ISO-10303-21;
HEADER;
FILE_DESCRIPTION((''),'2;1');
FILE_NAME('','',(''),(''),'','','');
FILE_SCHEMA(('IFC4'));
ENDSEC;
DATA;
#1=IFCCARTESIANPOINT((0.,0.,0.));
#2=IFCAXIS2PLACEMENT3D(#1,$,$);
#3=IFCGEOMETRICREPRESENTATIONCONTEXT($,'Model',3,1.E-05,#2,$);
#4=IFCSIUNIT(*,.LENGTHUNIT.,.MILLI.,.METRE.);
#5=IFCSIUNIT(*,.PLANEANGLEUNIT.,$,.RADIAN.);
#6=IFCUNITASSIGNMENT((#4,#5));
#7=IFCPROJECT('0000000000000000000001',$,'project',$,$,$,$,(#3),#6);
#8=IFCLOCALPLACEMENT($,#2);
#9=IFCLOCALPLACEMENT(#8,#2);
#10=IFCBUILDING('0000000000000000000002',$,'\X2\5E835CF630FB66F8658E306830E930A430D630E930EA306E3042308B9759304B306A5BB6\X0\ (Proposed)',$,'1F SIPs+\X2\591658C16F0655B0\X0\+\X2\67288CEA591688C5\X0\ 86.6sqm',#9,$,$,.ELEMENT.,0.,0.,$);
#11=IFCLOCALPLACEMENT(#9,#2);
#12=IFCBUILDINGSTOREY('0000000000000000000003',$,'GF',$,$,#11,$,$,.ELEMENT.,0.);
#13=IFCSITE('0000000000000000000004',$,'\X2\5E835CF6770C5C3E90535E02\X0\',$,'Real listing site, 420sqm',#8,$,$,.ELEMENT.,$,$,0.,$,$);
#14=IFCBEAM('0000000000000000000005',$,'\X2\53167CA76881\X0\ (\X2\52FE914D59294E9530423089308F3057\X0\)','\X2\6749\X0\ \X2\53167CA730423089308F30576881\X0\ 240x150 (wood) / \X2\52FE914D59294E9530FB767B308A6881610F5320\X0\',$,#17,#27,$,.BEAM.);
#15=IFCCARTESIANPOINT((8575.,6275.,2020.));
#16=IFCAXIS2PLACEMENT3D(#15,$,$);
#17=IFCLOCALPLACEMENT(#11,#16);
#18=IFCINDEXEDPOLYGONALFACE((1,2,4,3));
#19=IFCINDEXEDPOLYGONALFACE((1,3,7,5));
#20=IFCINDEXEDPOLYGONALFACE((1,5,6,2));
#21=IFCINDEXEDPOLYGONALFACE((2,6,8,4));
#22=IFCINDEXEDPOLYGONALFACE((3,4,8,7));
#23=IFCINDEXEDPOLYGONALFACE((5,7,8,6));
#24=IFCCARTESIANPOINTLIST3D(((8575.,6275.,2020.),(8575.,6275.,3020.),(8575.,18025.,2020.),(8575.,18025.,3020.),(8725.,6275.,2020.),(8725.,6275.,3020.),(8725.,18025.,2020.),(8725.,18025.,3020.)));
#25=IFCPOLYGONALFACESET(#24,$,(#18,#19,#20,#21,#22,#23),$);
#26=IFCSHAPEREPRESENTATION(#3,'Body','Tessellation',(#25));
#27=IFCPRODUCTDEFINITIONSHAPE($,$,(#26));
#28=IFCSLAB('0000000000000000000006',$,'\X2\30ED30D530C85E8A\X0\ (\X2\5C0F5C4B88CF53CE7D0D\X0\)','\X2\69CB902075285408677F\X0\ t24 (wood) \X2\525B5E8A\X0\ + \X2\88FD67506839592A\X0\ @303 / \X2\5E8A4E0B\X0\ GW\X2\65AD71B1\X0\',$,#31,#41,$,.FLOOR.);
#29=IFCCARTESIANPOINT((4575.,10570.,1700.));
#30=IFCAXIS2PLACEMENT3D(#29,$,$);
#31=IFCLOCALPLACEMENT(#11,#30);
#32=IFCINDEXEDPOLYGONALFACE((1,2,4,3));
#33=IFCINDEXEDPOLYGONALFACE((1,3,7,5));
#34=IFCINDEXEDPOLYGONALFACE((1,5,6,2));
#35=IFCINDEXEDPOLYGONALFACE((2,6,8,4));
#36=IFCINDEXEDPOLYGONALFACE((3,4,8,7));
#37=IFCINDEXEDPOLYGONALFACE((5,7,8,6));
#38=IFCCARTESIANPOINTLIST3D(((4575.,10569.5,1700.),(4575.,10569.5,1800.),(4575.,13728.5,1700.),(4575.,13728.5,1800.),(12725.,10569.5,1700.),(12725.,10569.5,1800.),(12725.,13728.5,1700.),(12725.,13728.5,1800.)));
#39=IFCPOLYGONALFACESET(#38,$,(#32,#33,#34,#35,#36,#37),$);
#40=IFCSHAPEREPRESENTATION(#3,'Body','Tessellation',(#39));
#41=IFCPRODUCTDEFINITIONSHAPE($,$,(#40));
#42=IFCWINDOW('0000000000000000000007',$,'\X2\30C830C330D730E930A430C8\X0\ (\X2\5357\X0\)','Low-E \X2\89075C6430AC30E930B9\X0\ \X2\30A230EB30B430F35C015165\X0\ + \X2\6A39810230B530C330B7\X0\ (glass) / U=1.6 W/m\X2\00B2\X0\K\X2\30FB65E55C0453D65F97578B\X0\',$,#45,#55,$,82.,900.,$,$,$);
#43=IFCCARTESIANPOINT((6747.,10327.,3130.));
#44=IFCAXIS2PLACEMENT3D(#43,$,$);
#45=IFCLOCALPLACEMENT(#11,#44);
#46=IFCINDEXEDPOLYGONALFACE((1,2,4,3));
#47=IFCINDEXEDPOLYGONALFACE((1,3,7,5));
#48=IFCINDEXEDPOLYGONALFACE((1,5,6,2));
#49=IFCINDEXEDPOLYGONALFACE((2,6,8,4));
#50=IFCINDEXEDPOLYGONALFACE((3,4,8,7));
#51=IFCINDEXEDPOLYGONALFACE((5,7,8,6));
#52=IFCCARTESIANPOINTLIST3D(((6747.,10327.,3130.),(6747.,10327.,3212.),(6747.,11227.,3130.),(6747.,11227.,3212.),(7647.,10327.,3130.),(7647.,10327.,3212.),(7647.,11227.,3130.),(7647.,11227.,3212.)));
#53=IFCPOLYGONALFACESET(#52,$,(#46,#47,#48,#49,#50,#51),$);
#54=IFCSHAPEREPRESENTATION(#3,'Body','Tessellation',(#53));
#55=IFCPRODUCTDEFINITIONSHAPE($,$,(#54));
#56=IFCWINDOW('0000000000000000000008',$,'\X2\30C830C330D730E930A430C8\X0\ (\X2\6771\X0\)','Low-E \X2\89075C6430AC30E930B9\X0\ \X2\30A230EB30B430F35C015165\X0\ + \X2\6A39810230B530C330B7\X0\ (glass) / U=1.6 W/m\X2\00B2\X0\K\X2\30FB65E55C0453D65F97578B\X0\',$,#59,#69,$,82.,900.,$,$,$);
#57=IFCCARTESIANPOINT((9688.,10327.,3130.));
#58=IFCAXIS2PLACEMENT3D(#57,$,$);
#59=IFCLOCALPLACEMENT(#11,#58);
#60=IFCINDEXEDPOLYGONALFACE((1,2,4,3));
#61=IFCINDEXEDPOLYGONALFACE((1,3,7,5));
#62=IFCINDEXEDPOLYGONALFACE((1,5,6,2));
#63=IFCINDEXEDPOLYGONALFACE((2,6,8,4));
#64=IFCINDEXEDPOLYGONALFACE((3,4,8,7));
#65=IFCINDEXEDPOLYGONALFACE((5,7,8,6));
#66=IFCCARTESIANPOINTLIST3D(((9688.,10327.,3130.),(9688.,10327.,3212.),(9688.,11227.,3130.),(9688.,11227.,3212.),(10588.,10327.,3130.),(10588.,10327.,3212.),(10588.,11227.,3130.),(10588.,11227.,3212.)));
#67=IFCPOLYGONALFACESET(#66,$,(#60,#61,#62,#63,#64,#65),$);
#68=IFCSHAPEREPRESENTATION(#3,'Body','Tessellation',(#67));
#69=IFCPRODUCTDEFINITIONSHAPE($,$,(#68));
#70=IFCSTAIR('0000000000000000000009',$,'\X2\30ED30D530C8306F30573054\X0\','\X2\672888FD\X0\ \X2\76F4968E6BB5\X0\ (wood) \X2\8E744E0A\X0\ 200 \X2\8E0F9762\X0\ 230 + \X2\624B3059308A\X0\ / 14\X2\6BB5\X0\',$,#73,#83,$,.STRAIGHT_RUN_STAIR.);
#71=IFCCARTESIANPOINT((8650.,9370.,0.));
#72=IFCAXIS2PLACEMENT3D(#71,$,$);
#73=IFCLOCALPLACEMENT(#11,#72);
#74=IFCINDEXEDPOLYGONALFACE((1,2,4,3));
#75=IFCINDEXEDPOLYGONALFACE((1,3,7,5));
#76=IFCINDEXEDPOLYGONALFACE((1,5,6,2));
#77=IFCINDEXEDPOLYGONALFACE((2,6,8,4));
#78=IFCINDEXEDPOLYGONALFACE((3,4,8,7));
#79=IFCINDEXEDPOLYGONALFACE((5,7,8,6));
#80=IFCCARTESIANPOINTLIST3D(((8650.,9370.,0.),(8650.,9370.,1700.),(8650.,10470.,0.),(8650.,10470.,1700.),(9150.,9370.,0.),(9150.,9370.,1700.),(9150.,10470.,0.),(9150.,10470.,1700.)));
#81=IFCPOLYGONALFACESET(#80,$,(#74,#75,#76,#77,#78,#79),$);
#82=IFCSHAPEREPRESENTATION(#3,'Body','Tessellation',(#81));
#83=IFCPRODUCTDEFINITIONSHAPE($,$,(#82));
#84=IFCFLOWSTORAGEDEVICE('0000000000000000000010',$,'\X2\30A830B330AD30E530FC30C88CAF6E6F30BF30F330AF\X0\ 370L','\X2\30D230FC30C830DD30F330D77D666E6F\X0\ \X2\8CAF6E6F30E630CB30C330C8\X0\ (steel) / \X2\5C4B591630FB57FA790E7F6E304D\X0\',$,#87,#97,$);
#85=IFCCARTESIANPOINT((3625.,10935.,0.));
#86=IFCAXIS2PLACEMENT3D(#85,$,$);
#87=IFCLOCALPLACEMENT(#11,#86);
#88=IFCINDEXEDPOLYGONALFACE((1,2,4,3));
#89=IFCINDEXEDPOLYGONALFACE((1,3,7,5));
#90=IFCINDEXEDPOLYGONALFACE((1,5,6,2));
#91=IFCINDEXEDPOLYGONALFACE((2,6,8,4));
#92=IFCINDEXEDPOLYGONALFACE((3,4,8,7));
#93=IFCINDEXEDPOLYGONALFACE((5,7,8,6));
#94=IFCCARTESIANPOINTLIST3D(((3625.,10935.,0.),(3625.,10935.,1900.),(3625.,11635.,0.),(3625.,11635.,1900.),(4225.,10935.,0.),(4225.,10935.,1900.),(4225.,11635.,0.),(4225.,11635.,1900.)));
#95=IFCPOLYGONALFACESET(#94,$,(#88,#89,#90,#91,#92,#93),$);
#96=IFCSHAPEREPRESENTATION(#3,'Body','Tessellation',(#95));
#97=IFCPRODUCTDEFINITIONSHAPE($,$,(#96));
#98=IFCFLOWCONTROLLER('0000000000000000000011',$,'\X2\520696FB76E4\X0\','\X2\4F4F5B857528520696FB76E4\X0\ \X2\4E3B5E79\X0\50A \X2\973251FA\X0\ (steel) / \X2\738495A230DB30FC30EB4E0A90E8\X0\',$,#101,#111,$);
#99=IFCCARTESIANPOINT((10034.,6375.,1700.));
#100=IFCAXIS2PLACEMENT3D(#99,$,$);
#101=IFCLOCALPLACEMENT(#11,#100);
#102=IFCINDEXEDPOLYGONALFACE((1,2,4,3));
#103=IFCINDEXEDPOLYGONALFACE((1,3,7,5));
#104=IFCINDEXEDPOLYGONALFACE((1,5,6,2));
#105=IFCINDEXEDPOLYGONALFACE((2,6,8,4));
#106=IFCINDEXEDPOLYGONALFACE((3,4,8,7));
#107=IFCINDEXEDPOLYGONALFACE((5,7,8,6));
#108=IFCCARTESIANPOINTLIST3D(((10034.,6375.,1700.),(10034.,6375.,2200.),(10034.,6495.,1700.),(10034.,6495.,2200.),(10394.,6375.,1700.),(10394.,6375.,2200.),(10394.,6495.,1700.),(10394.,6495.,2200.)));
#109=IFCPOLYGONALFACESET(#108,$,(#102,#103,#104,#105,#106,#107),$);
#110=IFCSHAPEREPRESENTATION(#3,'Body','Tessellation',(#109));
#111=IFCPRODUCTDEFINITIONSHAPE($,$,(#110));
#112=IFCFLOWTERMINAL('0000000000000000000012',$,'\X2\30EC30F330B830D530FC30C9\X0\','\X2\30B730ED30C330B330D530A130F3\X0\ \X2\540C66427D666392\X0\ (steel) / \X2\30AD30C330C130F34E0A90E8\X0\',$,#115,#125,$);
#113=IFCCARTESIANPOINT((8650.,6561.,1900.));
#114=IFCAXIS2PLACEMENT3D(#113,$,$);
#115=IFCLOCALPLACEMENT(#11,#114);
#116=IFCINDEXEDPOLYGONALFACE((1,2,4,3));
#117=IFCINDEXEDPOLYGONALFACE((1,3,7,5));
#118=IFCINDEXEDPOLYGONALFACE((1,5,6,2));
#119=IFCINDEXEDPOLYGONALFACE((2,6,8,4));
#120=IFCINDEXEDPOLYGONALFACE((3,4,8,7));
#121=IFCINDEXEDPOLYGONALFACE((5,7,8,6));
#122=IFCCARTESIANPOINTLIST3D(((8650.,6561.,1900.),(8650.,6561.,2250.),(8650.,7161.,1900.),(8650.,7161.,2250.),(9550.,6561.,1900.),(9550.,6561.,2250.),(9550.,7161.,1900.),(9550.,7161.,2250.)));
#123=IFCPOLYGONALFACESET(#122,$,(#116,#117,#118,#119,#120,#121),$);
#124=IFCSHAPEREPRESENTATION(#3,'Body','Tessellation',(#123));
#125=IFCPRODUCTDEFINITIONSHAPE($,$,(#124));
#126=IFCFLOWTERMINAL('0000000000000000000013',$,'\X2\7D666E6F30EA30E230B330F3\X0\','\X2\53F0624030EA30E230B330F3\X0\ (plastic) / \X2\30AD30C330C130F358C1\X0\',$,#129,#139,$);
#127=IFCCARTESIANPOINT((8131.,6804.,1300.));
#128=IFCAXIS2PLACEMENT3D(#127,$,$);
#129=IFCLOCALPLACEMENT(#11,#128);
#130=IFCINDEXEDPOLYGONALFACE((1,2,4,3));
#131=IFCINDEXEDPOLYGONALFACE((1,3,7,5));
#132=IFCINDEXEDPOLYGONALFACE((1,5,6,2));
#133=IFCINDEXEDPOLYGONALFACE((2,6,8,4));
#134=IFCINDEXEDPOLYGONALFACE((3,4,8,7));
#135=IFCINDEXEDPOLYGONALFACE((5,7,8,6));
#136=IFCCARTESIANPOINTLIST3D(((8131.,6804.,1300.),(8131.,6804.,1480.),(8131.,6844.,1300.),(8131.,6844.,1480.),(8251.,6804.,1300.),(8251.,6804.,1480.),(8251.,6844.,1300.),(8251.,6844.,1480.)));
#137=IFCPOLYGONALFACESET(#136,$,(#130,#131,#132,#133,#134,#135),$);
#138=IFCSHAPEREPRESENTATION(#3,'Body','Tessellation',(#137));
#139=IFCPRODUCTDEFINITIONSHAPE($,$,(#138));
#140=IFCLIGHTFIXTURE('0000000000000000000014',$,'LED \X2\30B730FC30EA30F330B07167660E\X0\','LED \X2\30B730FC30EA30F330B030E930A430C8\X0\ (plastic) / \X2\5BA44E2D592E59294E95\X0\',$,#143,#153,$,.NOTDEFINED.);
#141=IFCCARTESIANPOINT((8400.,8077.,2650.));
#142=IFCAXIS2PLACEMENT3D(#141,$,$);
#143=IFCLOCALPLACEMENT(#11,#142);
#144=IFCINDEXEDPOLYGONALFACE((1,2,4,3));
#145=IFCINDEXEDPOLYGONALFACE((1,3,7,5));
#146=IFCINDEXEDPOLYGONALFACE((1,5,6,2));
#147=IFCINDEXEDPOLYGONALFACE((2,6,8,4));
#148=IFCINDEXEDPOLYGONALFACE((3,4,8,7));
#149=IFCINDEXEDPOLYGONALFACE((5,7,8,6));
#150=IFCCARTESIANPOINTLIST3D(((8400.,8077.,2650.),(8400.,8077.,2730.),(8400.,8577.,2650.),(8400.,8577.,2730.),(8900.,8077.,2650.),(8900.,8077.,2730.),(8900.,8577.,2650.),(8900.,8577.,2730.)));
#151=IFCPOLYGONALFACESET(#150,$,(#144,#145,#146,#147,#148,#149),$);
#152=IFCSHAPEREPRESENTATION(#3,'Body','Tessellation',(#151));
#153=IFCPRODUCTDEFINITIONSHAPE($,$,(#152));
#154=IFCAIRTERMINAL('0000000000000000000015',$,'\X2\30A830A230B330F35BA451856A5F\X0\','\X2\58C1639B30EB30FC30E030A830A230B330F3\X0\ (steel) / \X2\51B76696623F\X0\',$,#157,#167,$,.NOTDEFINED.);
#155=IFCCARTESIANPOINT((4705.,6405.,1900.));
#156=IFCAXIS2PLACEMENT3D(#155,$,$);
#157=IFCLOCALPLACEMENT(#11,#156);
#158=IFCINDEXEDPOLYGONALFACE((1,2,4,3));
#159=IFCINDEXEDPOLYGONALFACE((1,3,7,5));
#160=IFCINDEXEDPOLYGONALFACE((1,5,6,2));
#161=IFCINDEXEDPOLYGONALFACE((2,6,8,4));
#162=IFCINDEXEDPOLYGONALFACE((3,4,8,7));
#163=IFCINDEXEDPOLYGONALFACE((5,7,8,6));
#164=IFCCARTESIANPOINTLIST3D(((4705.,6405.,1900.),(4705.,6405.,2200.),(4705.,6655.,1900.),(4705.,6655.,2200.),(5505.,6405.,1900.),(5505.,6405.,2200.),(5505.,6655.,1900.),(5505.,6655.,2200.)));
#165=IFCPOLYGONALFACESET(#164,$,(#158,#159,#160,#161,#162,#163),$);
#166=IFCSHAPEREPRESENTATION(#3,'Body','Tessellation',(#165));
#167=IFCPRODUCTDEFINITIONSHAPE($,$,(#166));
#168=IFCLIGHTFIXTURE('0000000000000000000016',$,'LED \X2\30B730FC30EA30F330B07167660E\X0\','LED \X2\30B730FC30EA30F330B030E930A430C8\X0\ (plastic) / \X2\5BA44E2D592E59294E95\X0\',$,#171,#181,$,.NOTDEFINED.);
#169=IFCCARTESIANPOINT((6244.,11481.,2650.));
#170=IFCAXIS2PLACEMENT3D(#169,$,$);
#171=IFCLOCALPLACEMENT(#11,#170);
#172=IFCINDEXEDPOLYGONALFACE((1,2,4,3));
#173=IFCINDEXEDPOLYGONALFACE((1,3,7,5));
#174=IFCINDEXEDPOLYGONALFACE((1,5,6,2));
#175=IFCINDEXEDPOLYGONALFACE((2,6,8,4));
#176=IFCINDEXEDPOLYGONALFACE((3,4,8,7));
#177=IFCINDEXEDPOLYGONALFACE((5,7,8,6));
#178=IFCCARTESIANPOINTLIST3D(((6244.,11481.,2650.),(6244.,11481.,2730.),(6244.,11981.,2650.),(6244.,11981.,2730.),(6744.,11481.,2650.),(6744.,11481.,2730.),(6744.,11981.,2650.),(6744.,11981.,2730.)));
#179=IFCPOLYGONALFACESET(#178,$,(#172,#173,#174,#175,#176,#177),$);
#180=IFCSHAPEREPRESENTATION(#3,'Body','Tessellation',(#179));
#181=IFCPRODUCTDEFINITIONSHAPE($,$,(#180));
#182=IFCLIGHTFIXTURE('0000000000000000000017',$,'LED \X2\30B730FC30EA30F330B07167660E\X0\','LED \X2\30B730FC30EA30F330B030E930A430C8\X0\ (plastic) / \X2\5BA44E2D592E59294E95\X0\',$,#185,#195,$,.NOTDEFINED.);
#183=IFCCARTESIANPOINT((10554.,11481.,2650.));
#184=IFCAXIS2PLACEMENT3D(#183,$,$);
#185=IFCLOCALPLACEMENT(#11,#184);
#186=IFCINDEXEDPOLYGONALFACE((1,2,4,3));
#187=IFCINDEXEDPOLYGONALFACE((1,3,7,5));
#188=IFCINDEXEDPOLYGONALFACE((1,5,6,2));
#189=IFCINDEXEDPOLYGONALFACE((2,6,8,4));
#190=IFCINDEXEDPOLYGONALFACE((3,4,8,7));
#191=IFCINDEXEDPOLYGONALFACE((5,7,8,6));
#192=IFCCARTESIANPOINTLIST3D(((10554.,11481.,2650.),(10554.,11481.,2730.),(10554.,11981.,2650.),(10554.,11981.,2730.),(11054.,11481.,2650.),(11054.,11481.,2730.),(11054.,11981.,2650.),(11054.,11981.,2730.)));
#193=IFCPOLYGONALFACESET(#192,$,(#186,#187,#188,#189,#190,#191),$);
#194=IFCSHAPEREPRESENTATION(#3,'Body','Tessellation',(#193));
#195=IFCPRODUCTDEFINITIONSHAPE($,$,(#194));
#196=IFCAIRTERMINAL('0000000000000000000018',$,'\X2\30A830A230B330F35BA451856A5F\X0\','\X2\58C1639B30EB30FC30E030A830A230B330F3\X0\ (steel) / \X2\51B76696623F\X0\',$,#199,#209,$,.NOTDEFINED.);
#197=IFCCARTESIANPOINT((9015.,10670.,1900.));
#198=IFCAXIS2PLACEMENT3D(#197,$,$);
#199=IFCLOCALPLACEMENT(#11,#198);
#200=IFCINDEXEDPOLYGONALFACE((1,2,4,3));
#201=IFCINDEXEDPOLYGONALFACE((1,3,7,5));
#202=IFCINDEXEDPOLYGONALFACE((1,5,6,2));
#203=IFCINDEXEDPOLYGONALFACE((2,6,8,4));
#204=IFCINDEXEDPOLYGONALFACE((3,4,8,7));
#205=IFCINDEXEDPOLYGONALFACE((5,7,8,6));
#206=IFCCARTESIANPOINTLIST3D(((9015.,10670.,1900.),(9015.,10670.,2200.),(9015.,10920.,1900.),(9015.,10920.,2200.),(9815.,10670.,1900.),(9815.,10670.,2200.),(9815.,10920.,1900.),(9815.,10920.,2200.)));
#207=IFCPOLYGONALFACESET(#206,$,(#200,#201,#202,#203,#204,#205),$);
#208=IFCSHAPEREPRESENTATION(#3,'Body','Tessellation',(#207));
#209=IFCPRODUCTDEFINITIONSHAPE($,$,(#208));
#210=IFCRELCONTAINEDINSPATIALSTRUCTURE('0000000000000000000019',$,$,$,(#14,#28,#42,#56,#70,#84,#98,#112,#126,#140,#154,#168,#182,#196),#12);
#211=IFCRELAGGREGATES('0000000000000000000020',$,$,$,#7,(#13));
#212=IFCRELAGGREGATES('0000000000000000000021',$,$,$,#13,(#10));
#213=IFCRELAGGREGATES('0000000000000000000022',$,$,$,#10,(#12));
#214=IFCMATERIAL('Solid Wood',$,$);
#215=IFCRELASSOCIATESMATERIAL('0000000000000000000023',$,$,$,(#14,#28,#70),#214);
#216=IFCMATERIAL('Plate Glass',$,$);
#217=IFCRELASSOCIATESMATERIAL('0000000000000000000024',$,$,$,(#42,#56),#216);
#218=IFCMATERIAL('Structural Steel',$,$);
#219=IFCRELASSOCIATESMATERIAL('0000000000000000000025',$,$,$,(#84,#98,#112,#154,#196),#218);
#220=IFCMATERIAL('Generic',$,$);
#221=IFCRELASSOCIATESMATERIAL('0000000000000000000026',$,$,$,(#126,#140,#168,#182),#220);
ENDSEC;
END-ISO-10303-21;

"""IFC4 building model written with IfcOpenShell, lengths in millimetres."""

from ifc_helpers import new_model, si_unit, frame, frame_2d, origin, place, context, project, spatial, rectangle, extrude, material, element, save


model = new_model("IFC4")

# Units and contexts
model_context = context("Model", 3, precision=1e-05, world=origin())
ifc_project = project(units=[si_unit("LENGTHUNIT", "METRE", prefix="MILLI"), si_unit("PLANEANGLEUNIT", "RADIAN")], contexts=[model_context])

# Site, building, storey
site_placement = place(None, origin())
site = spatial("IfcSite", under=ifc_project, at=site_placement, Name="広島県尾道市", ObjectType="Real listing site, 420sqm", CompositionType="ELEMENT", RefElevation=0.0)
building_placement = place(site_placement, origin())
building = spatial("IfcBuilding", under=site, at=building_placement, Name="広島・書斎とライブラリのある静かな家 (Proposed)", ObjectType="1F SIPs+外壁漆喰+木質外装 86.6sqm", CompositionType="ELEMENT", ElevationOfRefHeight=0.0, ElevationOfTerrain=0.0)
storey_placement = place(building_placement, origin())
storey = spatial("IfcBuildingStorey", under=building, at=storey_placement, Name="GF", CompositionType="ELEMENT", Elevation=0.0)

# Shared definitions
ifc_material_1 = material(Name="Solid Wood")

# Beam
beam_placement = place(storey_placement, frame((8575.0, 6275.0, 2020.0)))
element("IfcBeam", 1, at=beam_placement, inside=storey, material=ifc_material_1, Name="化粧梁 (勾配天井あらわし)", Description="杉 化粧あらわし梁 240x150 (wood) / 勾配天井・登り梁意匠", PredefinedType="BEAM", context=model_context, shape_type="SweptSolid", body=[
    extrude(rectangle(XDim=150.0, YDim=11750.0, at=frame_2d((75.0, 5875.0))), frame((8575.0, 6275.0, 2020.0)), (0.0, 0.0, 1.0), 1000.0),
])

# Slab
slab_placement = place(storey_placement, frame((4575.0, 10570.0, 1700.0)))
element("IfcSlab", 2, at=slab_placement, inside=storey, material=ifc_material_1, Name="ロフト床 (小屋裏収納)", Description="構造用合板 t24 (wood) 剛床 + 製材根太 @303 / 床下 GW断熱", PredefinedType="FLOOR", context=model_context, shape_type="SweptSolid", body=[
    extrude(rectangle(XDim=8150.0, YDim=3159.0, at=frame_2d((4075.0, 1579.0))), frame((4575.0, 10570.0, 1700.0)), (0.0, 0.0, 1.0), 100.0),
])

# Windows
ifc_material_2 = material(Name="Plate Glass")
window_1_placement = place(storey_placement, frame((6747.0, 10327.0, 3130.0)))
element("IfcWindow", 3, at=window_1_placement, inside=storey, material=ifc_material_2, Name="トップライト (南)", Description="Low-E 複層ガラス アルゴン封入 + 樹脂サッシ (glass) / U=1.6 W/m²K・日射取得型", OverallHeight=82.0, OverallWidth=900.0, context=model_context, shape_type="SweptSolid", body=[
    extrude(rectangle(XDim=900.0, YDim=900.0, at=frame_2d((450.0, 450.0))), frame((6747.0, 10327.0, 3130.0)), (0.0, 0.0, 1.0), 82.0),
])
window_2_placement = place(storey_placement, frame((9688.0, 10327.0, 3130.0)))
element("IfcWindow", 4, at=window_2_placement, inside=storey, material=ifc_material_2, Name="トップライト (東)", Description="Low-E 複層ガラス アルゴン封入 + 樹脂サッシ (glass) / U=1.6 W/m²K・日射取得型", OverallHeight=82.0, OverallWidth=900.0, context=model_context, shape_type="SweptSolid", body=[
    extrude(rectangle(XDim=900.0, YDim=900.0, at=frame_2d((450.0, 450.0))), frame((9688.0, 10327.0, 3130.0)), (0.0, 0.0, 1.0), 82.0),
])

# Stair
stair_placement = place(storey_placement, frame((8650.0, 9370.0, 0.0)))
element("IfcStair", 5, at=stair_placement, inside=storey, material=ifc_material_1, Name="ロフトはしご", Description="木製 直階段 (wood) 蹴上 200 踏面 230 + 手すり / 14段", PredefinedType="STRAIGHT_RUN_STAIR", context=model_context, shape_type="SweptSolid", body=[
    extrude(rectangle(XDim=500.0, YDim=1100.0, at=frame_2d((250.0, 550.0))), frame((8650.0, 9370.0, 0.0)), (0.0, 0.0, 1.0), 1700.0),
])

# Flow storage device
ifc_material_3 = material(Name="Structural Steel")
flow_storage_device_placement = place(storey_placement, frame((3625.0, 10935.0, 0.0)))
element("IfcFlowStorageDevice", 6, at=flow_storage_device_placement, inside=storey, material=ifc_material_3, Name="エコキュート貯湯タンク 370L", Description="ヒートポンプ給湯 貯湯ユニット (steel) / 屋外・基礎置き", context=model_context, shape_type="SweptSolid", body=[
    extrude(rectangle(XDim=600.0, YDim=700.0, at=frame_2d((300.0, 350.0))), frame((3625.0, 10935.0, 0.0)), (0.0, 0.0, 1.0), 1900.0),
])

# Flow controller
flow_controller_placement = place(storey_placement, frame((10034.0, 6375.0, 1700.0)))
element("IfcFlowController", 7, at=flow_controller_placement, inside=storey, material=ifc_material_3, Name="分電盤", Description="住宅用分電盤 主幹50A 露出 (steel) / 玄関ホール上部", context=model_context, shape_type="SweptSolid", body=[
    extrude(rectangle(XDim=360.0, YDim=120.0, at=frame_2d((180.0, 60.0))), frame((10034.0, 6375.0, 1700.0)), (0.0, 0.0, 1.0), 500.0),
])

# Flow terminals
flow_terminal_1_placement = place(storey_placement, frame((8650.0, 6561.0, 1900.0)))
element("IfcFlowTerminal", 8, at=flow_terminal_1_placement, inside=storey, material=ifc_material_3, Name="レンジフード", Description="シロッコファン 同時給排 (steel) / キッチン上部", context=model_context, shape_type="SweptSolid", body=[
    extrude(rectangle(XDim=900.0, YDim=600.0, at=frame_2d((450.0, 300.0))), frame((8650.0, 6561.0, 1900.0)), (0.0, 0.0, 1.0), 350.0),
])
ifc_material_4 = material(Name="Generic")
flow_terminal_2_placement = place(storey_placement, frame((8131.0, 6804.0, 1300.0)))
element("IfcFlowTerminal", 9, at=flow_terminal_2_placement, inside=storey, material=ifc_material_4, Name="給湯リモコン", Description="台所リモコン (plastic) / キッチン壁", context=model_context, shape_type="SweptSolid", body=[
    extrude(rectangle(XDim=120.0, YDim=40.0, at=frame_2d((60.0, 20.0))), frame((8131.0, 6804.0, 1300.0)), (0.0, 0.0, 1.0), 180.0),
])

# Light fixture
light_fixture_1_placement = place(storey_placement, frame((8400.0, 8077.0, 2650.0)))
element("IfcLightFixture", 10, at=light_fixture_1_placement, inside=storey, material=ifc_material_4, Name="LED シーリング照明", Description="LED シーリングライト (plastic) / 室中央天井", PredefinedType="NOTDEFINED", context=model_context, shape_type="SweptSolid", body=[
    extrude(rectangle(XDim=500.0, YDim=500.0, at=frame_2d((250.0, 250.0))), frame((8400.0, 8077.0, 2650.0)), (0.0, 0.0, 1.0), 80.0),
])

# Air terminal
air_terminal_1_placement = place(storey_placement, frame((4705.0, 6405.0, 1900.0)))
element("IfcAirTerminal", 11, at=air_terminal_1_placement, inside=storey, material=ifc_material_3, Name="エアコン室内機", Description="壁掛ルームエアコン (steel) / 冷暖房", PredefinedType="NOTDEFINED", context=model_context, shape_type="SweptSolid", body=[
    extrude(rectangle(XDim=800.0, YDim=250.0, at=frame_2d((400.0, 125.0))), frame((4705.0, 6405.0, 1900.0)), (0.0, 0.0, 1.0), 300.0),
])

# Light fixtures
light_fixture_2_placement = place(storey_placement, frame((6244.0, 11481.0, 2650.0)))
element("IfcLightFixture", 12, at=light_fixture_2_placement, inside=storey, material=ifc_material_4, Name="LED シーリング照明", Description="LED シーリングライト (plastic) / 室中央天井", PredefinedType="NOTDEFINED", context=model_context, shape_type="SweptSolid", body=[
    extrude(rectangle(XDim=500.0, YDim=500.0, at=frame_2d((250.0, 250.0))), frame((6244.0, 11481.0, 2650.0)), (0.0, 0.0, 1.0), 80.0),
])
light_fixture_3_placement = place(storey_placement, frame((10554.0, 11481.0, 2650.0)))
element("IfcLightFixture", 13, at=light_fixture_3_placement, inside=storey, material=ifc_material_4, Name="LED シーリング照明", Description="LED シーリングライト (plastic) / 室中央天井", PredefinedType="NOTDEFINED", context=model_context, shape_type="SweptSolid", body=[
    extrude(rectangle(XDim=500.0, YDim=500.0, at=frame_2d((250.0, 250.0))), frame((10554.0, 11481.0, 2650.0)), (0.0, 0.0, 1.0), 80.0),
])

# Air terminal
air_terminal_2_placement = place(storey_placement, frame((9015.0, 10670.0, 1900.0)))
element("IfcAirTerminal", 14, at=air_terminal_2_placement, inside=storey, material=ifc_material_3, Name="エアコン室内機", Description="壁掛ルームエアコン (steel) / 冷暖房", PredefinedType="NOTDEFINED", context=model_context, shape_type="SweptSolid", body=[
    extrude(rectangle(XDim=800.0, YDim=250.0, at=frame_2d((400.0, 125.0))), frame((9015.0, 10670.0, 1900.0)), (0.0, 0.0, 1.0), 300.0),
])

save(model, "model.ifc")
